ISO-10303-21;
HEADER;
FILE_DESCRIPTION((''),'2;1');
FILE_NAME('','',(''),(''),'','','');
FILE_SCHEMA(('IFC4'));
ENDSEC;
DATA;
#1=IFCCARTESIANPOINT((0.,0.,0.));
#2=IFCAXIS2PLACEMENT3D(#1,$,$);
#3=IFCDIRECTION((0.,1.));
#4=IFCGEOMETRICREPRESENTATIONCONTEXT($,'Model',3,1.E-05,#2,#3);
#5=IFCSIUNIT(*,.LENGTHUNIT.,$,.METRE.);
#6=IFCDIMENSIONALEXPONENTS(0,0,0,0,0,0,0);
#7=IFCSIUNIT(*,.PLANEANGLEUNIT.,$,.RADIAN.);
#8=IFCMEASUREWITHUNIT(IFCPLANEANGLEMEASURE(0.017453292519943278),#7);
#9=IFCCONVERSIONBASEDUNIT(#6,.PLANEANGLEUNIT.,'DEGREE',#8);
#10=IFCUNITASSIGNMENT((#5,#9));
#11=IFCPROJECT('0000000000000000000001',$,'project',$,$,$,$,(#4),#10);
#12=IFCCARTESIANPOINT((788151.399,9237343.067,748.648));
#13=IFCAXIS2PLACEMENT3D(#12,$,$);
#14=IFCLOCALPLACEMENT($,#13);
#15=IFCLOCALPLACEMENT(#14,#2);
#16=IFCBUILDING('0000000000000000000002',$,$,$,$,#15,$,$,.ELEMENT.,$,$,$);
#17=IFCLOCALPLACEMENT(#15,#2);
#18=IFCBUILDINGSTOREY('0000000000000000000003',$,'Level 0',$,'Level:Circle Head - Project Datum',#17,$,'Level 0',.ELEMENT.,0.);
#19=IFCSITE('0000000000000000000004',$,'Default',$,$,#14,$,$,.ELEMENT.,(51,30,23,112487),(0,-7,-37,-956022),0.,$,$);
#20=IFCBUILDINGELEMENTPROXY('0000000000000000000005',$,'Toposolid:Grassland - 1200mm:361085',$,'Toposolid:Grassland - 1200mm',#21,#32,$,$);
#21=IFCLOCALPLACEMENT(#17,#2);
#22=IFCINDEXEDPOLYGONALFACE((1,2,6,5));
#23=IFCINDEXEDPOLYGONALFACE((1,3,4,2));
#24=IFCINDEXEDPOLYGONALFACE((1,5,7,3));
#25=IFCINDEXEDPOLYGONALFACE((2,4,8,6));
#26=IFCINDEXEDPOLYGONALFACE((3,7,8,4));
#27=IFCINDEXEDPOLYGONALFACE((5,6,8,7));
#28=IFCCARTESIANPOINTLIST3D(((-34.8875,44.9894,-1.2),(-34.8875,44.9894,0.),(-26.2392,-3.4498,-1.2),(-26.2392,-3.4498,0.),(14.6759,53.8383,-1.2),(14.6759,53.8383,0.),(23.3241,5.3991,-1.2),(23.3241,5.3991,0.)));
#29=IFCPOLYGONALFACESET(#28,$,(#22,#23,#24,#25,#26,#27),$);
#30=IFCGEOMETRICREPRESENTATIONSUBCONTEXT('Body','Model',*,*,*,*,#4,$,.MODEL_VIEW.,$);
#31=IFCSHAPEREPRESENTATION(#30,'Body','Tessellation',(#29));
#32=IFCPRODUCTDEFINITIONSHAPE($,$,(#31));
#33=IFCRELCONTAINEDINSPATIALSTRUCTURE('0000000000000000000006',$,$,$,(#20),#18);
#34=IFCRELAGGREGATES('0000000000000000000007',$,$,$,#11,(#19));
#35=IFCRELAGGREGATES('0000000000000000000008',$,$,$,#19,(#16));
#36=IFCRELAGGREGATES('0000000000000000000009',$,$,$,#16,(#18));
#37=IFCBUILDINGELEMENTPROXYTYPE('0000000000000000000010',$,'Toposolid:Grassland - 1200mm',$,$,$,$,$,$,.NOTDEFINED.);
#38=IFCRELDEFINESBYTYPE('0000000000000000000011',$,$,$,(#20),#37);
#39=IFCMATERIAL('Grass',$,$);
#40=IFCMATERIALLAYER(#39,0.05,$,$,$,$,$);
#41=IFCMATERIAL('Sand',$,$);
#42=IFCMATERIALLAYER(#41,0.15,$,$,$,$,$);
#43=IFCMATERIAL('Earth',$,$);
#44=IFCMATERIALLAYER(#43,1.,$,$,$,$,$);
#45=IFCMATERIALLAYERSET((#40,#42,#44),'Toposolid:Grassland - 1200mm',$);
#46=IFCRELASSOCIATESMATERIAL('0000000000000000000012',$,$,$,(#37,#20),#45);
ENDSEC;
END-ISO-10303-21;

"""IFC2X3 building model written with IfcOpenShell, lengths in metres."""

from ifc_helpers import new_model, entity, si_unit, converted_unit, direction, frame, frame_2d, origin, place, context, subcontext, project, spatial, rectangle, extrude, material, layer, layer_set, layer_usage, type_object, element, save


model = new_model("IFC2X3")

# Units and contexts
model_context = context("Model", 3, precision=1e-05, world=origin(), true_north=direction((0.0, 1.0)))
body_context = subcontext(model_context, "Body", "Model", "MODEL_VIEW")
ifc_project = project(units=[si_unit("LENGTHUNIT", "METRE"), converted_unit("PLANEANGLEUNIT", "DEGREE", entity("IfcPlaneAngleMeasure", 0.017453292519943278), si_unit("PLANEANGLEUNIT", "RADIAN"), dimensions=[0, 0, 0, 0, 0, 0, 0])], contexts=[model_context])

# Site, building, storey
site_placement = place(None, frame((788151.399, 9237343.067, 748.648)))
site = spatial("IfcSite", under=ifc_project, at=site_placement, Name="Default", CompositionType="ELEMENT", RefLatitude=(51, 30, 23, 112487), RefLongitude=(0, -7, -37, -956022), RefElevation=0.0)
building_placement = place(site_placement, origin())
building = spatial("IfcBuilding", under=site, at=building_placement, CompositionType="ELEMENT")
storey_placement = place(building_placement, origin())
storey = spatial("IfcBuildingStorey", under=building, at=storey_placement, Name="Level 0", ObjectType="Level:Circle Head - Project Datum", LongName="Level 0", CompositionType="ELEMENT", Elevation=0.0)

# Building element proxy
ifc_material_1 = material(Name="Grass")
ifc_layer_1 = layer(ifc_material_1, 0.05)
ifc_material_2 = material(Name="Sand")
ifc_layer_2 = layer(ifc_material_2, 0.15)
ifc_material_3 = material(Name="Earth")
ifc_layer_3 = layer(ifc_material_3, 1.0)
ifc_layer_set = layer_set([ifc_layer_1, ifc_layer_2, ifc_layer_3], Name="Toposolid:Grassland - 1200mm")
ifc_layer_usage = layer_usage(ifc_layer_set, "AXIS3", "NEGATIVE", 0.0)
building_element_proxy_type = type_object("IfcBuildingElementProxyType", Name="Toposolid:Grassland - 1200mm", PredefinedType="NOTDEFINED", material=ifc_layer_set)
proxy_placement = place(storey_placement, origin())
element("IfcBuildingElementProxy", 1, at=proxy_placement, inside=storey, type_object=building_element_proxy_type, material=ifc_layer_usage, Name="Toposolid:Grassland - 1200mm:361085", ObjectType="Toposolid:Grassland - 1200mm", context=body_context, shape_type="SweptSolid", body=[
    extrude(rectangle(XDim=50.3471, YDim=49.2052, at=frame_2d((0.0, 0.0), x_axis=(1.0, 0.0))), frame((-5.7817, 25.1943, -1.2), z_axis=(0.0, 0.0, 1.0), x_axis=(-0.984433, -0.175758, 0.0)), (0.0, 0.0, 1.0), 1.2),
])

save(model, "model.ifc")
